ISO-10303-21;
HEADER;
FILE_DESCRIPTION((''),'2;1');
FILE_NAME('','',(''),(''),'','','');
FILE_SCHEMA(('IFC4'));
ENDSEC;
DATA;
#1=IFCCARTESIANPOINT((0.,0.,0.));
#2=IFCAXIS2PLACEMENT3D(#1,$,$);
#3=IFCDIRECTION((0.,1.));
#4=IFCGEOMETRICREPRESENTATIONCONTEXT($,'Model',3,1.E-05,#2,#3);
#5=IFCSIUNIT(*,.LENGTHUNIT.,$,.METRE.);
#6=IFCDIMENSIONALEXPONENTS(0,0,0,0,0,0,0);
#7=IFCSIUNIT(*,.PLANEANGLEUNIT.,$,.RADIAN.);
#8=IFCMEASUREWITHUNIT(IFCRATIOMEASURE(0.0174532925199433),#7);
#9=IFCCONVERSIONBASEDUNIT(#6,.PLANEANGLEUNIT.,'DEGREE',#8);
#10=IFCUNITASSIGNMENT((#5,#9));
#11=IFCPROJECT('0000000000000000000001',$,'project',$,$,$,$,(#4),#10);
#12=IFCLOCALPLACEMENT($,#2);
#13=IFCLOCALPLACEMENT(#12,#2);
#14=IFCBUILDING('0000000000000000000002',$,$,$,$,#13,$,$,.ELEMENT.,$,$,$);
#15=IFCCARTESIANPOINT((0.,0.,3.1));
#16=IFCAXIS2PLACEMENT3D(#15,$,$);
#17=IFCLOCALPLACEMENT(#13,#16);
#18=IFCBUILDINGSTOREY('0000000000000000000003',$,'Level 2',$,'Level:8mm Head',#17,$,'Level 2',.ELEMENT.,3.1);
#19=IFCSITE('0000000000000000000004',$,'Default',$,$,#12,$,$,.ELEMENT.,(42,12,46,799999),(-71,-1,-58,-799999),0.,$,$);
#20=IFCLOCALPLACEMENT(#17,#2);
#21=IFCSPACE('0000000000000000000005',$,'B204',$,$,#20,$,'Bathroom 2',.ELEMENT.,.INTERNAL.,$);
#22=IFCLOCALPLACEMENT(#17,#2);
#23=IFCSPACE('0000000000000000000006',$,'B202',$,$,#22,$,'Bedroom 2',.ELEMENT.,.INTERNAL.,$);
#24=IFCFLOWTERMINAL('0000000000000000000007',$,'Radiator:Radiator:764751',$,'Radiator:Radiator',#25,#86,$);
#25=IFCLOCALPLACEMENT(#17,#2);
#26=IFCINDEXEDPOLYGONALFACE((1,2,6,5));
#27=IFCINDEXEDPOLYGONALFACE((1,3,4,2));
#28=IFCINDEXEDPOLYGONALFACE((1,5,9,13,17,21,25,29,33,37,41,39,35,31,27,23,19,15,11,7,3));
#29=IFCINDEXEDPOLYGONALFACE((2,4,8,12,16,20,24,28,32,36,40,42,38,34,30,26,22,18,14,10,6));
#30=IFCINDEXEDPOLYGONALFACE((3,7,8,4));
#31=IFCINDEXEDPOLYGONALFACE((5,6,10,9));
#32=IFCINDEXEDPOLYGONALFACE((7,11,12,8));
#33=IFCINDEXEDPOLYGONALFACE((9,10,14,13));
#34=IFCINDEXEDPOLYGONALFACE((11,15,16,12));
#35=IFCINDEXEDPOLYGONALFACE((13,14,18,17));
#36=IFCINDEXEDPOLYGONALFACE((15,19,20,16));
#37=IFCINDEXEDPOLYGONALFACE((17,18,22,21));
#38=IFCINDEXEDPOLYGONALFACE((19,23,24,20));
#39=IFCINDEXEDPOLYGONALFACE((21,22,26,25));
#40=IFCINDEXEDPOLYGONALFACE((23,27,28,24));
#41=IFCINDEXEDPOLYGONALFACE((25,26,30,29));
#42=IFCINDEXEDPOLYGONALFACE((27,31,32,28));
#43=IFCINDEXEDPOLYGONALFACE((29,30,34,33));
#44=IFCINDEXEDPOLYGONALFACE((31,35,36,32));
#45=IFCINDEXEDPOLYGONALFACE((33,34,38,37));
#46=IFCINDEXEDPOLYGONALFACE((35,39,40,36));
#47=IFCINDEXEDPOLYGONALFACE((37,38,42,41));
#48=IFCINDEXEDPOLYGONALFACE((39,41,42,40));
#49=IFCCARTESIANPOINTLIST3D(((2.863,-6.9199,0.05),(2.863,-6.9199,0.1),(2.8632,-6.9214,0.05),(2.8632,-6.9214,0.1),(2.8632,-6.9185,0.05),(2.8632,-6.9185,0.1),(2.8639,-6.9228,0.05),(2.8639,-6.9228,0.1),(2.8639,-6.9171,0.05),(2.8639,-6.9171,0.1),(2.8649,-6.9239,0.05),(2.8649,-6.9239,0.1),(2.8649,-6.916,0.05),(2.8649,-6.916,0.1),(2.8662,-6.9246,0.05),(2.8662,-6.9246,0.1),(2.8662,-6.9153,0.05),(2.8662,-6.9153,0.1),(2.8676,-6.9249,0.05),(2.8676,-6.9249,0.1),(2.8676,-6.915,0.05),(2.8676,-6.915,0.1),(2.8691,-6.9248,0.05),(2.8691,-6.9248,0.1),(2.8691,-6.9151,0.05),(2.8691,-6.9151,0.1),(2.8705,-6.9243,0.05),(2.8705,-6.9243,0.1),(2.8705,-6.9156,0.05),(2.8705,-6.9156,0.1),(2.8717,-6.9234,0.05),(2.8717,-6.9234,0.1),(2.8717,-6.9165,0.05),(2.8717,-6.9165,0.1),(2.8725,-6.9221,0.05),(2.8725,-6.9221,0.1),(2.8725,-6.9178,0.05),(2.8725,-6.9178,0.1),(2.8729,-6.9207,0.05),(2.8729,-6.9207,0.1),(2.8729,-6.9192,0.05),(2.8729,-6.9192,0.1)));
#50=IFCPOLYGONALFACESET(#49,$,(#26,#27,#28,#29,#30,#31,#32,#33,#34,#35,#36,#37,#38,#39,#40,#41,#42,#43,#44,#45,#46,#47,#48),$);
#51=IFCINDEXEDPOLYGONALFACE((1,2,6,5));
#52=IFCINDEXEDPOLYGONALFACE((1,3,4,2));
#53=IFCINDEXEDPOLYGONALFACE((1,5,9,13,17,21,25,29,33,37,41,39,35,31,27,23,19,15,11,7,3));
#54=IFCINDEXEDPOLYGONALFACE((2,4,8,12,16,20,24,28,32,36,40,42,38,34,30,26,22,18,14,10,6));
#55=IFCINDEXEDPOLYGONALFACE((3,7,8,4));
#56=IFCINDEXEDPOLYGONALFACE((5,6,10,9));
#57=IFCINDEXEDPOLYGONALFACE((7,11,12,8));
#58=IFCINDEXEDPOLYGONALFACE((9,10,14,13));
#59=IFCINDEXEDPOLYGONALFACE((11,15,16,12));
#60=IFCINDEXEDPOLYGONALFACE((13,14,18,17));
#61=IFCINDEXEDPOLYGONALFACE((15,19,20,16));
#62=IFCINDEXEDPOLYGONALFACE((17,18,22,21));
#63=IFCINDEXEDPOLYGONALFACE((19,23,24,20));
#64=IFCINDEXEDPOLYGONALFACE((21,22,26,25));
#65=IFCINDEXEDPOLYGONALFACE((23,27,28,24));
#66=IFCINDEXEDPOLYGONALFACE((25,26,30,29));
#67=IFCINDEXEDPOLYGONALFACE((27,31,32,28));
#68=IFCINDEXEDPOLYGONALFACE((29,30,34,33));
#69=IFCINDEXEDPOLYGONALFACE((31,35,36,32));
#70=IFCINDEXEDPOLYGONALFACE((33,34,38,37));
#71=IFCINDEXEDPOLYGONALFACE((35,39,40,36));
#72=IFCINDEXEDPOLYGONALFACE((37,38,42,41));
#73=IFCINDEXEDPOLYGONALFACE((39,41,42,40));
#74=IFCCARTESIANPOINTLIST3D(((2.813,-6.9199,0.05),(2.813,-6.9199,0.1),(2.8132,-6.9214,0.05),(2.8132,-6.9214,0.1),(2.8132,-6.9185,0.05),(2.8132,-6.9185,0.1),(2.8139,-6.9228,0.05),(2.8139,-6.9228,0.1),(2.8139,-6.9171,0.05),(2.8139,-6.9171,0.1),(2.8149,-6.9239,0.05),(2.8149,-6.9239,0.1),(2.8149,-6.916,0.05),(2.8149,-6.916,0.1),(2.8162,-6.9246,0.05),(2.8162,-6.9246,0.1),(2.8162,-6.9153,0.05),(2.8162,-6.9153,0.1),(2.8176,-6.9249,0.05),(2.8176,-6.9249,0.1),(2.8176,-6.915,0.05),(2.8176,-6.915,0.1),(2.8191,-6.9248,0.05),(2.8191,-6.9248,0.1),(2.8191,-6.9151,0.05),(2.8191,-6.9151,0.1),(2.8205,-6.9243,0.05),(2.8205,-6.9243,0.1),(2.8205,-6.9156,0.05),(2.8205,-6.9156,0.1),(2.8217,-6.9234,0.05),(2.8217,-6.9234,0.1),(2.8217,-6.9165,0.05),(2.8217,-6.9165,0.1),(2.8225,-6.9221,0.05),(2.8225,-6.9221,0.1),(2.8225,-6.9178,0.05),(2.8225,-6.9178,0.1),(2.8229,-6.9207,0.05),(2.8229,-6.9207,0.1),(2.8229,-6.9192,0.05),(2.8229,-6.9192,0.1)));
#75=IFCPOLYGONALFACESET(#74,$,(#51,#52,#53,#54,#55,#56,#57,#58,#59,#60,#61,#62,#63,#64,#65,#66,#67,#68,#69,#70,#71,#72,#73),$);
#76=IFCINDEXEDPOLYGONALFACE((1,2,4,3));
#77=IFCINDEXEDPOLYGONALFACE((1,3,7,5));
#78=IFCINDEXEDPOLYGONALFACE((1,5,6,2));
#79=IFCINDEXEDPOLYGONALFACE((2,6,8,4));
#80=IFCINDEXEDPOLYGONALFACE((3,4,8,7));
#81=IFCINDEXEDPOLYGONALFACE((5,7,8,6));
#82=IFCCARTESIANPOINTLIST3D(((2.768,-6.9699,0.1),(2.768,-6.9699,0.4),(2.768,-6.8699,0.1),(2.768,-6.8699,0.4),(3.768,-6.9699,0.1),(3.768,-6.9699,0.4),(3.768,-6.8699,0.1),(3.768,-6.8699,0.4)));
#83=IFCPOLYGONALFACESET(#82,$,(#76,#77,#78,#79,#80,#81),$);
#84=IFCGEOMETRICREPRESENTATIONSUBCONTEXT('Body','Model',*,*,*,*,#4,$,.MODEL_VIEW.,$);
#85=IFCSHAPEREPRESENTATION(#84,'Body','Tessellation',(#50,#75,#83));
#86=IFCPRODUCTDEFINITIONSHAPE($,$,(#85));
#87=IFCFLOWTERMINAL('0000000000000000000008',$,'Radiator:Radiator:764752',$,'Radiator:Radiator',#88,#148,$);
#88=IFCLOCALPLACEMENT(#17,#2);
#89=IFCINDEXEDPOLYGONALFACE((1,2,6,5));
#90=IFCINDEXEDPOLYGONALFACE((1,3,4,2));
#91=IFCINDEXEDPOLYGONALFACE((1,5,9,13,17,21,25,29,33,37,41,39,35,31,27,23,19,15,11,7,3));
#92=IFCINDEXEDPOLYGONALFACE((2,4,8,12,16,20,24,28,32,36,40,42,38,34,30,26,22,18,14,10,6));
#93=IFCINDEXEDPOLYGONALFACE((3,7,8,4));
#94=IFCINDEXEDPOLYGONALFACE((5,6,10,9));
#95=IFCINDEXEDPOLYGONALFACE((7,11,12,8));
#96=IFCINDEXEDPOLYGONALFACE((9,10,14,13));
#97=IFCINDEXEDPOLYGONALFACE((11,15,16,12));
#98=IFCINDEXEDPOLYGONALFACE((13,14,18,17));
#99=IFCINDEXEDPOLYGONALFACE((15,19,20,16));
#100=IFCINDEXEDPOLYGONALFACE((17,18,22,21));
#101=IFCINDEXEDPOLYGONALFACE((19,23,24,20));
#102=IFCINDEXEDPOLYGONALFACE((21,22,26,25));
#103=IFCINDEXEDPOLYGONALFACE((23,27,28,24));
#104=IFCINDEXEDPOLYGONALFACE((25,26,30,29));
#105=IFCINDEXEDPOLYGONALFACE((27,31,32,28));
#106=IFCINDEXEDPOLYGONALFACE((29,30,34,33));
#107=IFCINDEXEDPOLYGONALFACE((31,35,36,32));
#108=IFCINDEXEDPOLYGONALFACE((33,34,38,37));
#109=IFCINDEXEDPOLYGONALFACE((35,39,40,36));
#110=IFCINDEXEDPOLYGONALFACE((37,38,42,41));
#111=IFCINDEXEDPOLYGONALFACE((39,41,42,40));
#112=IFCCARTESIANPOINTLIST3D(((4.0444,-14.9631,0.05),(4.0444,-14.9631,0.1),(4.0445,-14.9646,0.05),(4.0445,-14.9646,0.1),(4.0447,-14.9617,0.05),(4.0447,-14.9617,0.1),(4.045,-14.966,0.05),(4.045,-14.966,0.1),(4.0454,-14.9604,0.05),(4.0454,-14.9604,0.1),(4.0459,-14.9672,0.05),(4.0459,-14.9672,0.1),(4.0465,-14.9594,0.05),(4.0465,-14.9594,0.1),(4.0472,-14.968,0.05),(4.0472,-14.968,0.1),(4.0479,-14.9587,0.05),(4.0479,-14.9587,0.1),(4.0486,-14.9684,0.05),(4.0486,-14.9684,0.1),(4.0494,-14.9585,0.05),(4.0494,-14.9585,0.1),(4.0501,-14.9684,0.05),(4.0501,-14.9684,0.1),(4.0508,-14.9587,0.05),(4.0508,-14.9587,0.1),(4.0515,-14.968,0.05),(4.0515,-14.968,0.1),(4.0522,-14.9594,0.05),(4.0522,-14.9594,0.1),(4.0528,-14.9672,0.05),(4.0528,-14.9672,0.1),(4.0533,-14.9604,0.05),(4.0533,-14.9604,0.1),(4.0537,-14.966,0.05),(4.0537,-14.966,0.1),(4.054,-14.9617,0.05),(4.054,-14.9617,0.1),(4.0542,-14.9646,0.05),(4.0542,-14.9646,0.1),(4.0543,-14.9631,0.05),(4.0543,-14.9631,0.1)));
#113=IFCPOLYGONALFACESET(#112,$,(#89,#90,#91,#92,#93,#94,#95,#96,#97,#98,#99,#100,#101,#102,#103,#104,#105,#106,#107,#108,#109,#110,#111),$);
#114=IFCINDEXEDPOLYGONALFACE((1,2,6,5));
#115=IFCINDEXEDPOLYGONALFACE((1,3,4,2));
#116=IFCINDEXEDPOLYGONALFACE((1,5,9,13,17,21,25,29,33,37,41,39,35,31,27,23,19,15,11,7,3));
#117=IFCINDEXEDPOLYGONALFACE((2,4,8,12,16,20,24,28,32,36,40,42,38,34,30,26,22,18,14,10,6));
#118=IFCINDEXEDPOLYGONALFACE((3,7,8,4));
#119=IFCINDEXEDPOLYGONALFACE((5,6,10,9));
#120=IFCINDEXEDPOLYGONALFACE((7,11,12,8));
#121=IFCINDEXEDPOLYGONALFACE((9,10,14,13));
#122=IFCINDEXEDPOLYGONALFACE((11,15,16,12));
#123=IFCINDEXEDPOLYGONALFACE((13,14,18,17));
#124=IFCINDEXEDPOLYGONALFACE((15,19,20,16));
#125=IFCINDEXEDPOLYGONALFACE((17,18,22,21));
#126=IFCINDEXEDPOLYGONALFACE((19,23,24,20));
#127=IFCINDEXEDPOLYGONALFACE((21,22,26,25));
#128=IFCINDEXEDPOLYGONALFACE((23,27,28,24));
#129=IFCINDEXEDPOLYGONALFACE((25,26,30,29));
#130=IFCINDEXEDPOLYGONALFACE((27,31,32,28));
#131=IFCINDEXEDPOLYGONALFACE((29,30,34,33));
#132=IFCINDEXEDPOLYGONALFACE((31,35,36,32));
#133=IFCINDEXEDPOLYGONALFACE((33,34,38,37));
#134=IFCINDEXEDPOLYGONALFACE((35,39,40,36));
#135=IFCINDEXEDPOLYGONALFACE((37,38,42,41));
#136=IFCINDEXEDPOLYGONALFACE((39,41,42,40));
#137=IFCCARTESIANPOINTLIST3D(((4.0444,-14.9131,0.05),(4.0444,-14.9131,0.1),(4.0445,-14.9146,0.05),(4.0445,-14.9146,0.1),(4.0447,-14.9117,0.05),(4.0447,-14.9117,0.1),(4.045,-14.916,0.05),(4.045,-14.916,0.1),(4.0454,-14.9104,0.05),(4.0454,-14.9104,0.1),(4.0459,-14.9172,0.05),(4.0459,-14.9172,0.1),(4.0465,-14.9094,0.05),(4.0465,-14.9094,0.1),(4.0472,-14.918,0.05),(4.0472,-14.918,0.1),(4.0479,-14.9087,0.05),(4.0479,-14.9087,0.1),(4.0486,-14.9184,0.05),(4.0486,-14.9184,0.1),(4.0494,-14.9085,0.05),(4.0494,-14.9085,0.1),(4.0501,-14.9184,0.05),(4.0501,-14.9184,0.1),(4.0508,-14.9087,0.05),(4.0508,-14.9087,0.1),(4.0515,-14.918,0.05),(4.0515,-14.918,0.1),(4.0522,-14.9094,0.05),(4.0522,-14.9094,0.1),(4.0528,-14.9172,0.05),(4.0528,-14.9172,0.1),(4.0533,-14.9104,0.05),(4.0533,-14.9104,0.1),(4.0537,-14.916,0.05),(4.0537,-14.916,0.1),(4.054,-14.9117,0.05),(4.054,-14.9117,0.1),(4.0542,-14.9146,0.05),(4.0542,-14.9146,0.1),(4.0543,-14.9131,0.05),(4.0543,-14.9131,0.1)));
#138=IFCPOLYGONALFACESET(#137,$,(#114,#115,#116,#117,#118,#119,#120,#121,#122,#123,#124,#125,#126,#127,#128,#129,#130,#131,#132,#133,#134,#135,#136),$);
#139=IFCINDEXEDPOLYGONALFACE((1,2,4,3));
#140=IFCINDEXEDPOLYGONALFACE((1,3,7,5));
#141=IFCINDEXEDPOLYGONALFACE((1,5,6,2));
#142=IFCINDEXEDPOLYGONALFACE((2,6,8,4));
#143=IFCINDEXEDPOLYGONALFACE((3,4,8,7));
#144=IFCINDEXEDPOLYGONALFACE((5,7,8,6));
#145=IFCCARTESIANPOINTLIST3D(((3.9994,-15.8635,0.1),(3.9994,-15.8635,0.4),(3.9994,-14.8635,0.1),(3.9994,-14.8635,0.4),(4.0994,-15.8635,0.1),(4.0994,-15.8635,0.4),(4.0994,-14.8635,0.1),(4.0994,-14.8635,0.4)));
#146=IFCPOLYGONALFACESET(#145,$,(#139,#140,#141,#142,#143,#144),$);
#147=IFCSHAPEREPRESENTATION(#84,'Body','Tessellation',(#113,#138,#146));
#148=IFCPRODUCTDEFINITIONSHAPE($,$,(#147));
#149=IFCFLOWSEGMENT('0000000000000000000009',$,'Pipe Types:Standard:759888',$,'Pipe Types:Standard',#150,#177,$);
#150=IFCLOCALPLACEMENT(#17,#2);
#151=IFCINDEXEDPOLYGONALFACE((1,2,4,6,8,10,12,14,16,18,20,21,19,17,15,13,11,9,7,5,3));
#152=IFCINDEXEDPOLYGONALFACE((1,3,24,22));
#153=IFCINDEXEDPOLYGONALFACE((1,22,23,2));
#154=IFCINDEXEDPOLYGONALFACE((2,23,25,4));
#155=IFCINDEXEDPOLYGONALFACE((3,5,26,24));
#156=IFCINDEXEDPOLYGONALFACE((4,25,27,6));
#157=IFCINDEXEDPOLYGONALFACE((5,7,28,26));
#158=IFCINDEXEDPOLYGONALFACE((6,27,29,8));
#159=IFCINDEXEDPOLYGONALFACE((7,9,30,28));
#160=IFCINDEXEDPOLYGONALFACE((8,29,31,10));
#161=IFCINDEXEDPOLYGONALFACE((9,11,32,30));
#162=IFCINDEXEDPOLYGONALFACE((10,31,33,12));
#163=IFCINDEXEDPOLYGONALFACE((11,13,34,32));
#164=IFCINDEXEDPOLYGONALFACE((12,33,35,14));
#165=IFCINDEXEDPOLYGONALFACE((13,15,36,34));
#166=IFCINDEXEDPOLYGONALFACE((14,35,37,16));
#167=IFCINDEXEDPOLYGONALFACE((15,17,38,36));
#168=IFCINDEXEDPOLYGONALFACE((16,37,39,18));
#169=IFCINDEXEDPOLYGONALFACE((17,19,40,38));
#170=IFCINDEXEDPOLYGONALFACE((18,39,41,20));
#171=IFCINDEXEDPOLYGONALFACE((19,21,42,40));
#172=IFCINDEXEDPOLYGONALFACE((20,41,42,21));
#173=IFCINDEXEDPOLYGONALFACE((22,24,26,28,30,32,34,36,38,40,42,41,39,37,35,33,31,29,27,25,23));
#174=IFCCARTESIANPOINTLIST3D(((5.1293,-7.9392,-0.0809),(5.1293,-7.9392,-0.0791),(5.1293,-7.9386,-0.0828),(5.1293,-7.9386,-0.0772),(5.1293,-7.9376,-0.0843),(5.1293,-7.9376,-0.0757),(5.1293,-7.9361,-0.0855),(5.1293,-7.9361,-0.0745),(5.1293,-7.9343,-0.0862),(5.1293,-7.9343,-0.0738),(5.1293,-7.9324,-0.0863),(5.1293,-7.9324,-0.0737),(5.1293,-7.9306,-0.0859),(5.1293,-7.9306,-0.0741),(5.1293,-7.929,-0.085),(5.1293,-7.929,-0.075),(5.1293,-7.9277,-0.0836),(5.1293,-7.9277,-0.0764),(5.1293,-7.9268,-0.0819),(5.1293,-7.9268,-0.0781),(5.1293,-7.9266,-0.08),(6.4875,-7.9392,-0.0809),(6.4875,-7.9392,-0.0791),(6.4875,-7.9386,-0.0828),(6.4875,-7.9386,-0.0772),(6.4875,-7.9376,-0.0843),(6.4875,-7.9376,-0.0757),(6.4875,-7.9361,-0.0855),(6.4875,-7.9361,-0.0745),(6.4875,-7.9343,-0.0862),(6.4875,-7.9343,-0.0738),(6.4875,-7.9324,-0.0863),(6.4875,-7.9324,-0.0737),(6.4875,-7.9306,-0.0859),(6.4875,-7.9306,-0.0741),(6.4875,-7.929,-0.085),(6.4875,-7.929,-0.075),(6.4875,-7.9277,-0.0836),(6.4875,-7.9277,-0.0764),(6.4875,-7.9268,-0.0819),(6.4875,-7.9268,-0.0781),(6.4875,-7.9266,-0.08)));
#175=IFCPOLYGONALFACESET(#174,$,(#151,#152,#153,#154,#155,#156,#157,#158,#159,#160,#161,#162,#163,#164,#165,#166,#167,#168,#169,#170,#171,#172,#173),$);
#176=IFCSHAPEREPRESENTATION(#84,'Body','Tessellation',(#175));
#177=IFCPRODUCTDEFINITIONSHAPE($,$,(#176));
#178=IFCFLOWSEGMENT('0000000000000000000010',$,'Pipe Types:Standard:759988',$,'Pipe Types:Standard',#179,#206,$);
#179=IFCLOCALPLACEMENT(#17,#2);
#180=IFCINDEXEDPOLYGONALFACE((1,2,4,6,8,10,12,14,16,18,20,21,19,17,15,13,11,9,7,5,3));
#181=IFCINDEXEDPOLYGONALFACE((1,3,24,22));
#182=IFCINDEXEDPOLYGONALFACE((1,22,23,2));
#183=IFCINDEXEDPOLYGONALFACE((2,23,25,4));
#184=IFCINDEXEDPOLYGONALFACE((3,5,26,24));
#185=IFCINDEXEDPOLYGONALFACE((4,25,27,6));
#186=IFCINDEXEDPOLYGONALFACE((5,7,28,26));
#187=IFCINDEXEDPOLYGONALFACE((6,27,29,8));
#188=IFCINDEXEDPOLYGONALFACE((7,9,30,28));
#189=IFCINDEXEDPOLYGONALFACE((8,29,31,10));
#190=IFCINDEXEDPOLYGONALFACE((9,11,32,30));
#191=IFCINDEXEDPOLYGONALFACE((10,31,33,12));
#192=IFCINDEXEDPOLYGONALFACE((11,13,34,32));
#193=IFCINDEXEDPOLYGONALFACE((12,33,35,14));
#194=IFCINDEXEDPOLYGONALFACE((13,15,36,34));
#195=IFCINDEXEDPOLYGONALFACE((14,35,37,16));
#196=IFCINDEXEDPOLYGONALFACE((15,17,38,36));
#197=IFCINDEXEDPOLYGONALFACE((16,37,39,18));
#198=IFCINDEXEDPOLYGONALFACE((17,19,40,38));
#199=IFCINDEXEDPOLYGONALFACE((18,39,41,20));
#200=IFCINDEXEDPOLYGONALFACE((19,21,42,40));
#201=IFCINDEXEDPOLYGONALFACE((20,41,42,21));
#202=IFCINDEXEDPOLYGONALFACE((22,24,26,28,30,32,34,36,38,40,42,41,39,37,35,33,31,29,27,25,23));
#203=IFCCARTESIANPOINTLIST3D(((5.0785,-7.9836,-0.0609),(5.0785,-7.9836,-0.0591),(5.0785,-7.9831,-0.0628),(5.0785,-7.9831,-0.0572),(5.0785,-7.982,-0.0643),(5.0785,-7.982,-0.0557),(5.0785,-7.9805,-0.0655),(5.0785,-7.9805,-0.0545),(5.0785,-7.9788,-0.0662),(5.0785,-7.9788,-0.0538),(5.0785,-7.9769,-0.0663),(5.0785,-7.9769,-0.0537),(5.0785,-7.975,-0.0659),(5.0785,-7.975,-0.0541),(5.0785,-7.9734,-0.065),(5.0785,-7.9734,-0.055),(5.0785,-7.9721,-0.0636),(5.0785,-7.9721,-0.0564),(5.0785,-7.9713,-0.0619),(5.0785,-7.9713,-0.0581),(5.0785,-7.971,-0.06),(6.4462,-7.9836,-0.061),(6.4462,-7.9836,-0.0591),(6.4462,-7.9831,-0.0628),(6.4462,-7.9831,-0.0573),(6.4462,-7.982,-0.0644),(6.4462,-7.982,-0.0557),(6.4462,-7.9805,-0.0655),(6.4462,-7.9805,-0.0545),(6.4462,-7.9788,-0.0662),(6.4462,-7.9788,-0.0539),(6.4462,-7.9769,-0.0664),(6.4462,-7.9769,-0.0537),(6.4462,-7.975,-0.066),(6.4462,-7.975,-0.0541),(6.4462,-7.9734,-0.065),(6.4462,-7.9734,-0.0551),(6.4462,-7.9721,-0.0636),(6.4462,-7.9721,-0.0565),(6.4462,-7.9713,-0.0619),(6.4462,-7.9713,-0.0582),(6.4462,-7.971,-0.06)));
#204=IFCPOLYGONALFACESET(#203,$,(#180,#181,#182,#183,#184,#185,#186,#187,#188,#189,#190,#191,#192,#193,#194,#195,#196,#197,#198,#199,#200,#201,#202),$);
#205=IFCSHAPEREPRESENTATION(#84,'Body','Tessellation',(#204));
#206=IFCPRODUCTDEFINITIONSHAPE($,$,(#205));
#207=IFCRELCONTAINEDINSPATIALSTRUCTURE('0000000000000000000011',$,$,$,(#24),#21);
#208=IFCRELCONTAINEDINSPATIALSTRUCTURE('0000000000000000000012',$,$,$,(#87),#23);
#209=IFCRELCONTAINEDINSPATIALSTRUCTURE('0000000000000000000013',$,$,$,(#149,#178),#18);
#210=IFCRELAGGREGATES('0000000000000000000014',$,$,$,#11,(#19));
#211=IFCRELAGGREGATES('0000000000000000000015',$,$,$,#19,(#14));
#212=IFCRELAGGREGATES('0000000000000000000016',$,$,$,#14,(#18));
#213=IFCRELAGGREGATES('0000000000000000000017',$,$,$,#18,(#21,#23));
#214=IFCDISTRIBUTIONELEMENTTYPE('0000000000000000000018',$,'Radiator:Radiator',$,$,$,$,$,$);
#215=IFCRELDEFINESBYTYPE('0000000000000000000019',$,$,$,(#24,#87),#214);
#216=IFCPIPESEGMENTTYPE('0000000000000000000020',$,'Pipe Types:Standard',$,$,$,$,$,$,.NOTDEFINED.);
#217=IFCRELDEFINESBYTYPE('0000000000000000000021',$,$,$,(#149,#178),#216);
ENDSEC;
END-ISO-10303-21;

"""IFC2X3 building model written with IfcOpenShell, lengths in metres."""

from ifc_helpers import new_model, entity, si_unit, converted_unit, direction, frame, frame_2d, origin, origin_2d_with_axis, place, context, subcontext, project, spatial, rectangle, circle, extrude, source, transform, mapped, type_object, type_shapes, element, save


model = new_model("IFC2X3")

# Units and contexts
model_context = context("Model", 3, precision=1e-05, world=origin(), true_north=direction((0.0, 1.0)))
body_context = subcontext(model_context, "Body", "Model", "MODEL_VIEW")
ifc_project = project(units=[si_unit("LENGTHUNIT", "METRE"), converted_unit("PLANEANGLEUNIT", "DEGREE", entity("IfcRatioMeasure", 0.0174532925199433), si_unit("PLANEANGLEUNIT", "RADIAN"), dimensions=[0, 0, 0, 0, 0, 0, 0])], contexts=[model_context])

# Site, building, storey
site_placement = place(None, origin())
site = spatial("IfcSite", under=ifc_project, at=site_placement, Name="Default", CompositionType="ELEMENT", RefLatitude=(42, 12, 46, 799999), RefLongitude=(-71, -1, -58, -799999), RefElevation=0.0)
building_placement = place(site_placement, origin())
building = spatial("IfcBuilding", under=site, at=building_placement, CompositionType="ELEMENT")
storey_placement = place(building_placement, frame((0.0, 0.0, 3.1)))
storey = spatial("IfcBuildingStorey", under=building, at=storey_placement, Name="Level 2", ObjectType="Level:8mm Head", LongName="Level 2", CompositionType="ELEMENT", Elevation=3.1)

# Shared definitions
distribution_element_type = type_object("IfcDistributionElementType", Name="Radiator:Radiator")
shared_shape = source(origin(), body_context, "Body", "SweptSolid", [
    extrude(circle(Radius=0.005, at=frame_2d((0.0, 0.0), x_axis=(1.0, 0.0))), frame((0.4, 0.0, -0.05)), (0.0, 0.0, 1.0), 0.05),
    extrude(circle(Radius=0.005, at=frame_2d((0.0, 0.0), x_axis=(1.0, 0.0))), frame((0.45, 0.0, -0.05)), (0.0, 0.0, 1.0), 0.05),
    extrude(rectangle(XDim=1.0, YDim=0.1, at=origin_2d_with_axis()), frame((0.0, 0.0, 0.0), z_axis=(0.0, 0.0, 1.0), x_axis=(-1.0, 0.0, 0.0)), (0.0, 0.0, 1.0), 0.3),
])
type_shapes(distribution_element_type, [shared_shape])

# Shared definitions
space_1_placement = place(storey_placement, origin())
space_1 = spatial("IfcSpace", under=storey, at=space_1_placement, Name="B204", LongName="Bathroom 2", CompositionType="ELEMENT", InteriorOrExteriorSpace="INTERNAL")

# Flow terminal
flow_terminal_1_placement = place(space_1_placement, frame((3.268, -6.9199, 0.1), z_axis=(0.0, 0.0, 1.0), x_axis=(-1.0, 0.0, 0.0)))
element("IfcFlowTerminal", 1, at=flow_terminal_1_placement, inside=space_1, type_object=distribution_element_type, Name="Radiator:Radiator:764751", ObjectType="Radiator:Radiator", context=body_context, shape_type="MappedRepresentation", body=[
    mapped(shared_shape, transform((0.0, 0.0, 0.0), scale=1.0)),
])

# Shared definitions
space_2_placement = place(storey_placement, origin())
space_2 = spatial("IfcSpace", under=storey, at=space_2_placement, Name="B202", LongName="Bedroom 2", CompositionType="ELEMENT", InteriorOrExteriorSpace="INTERNAL")

# Flow terminal
flow_terminal_2_placement = place(space_2_placement, frame((4.0494, -15.3635, 0.1), z_axis=(0.0, 0.0, 1.0), x_axis=(0.0, 1.0, 0.0)))
element("IfcFlowTerminal", 2, at=flow_terminal_2_placement, inside=space_2, type_object=distribution_element_type, Name="Radiator:Radiator:764752", ObjectType="Radiator:Radiator", context=body_context, shape_type="MappedRepresentation", body=[
    mapped(shared_shape, transform((0.0, 0.0, 0.0), scale=1.0)),
])

# Flow segments
pipe_segment_type = type_object("IfcPipeSegmentType", Name="Pipe Types:Standard", PredefinedType="NOTDEFINED")
flow_segment_1_placement = place(storey_placement, origin())
element("IfcFlowSegment", 3, at=flow_segment_1_placement, inside=storey, type_object=pipe_segment_type, Name="Pipe Types:Standard:759888", ObjectType="Pipe Types:Standard", context=body_context, shape_type="SweptSolid", body=[
    extrude(circle(Radius=0.0063, at=frame_2d((0.0, 0.0), x_axis=(1.0, 0.0))), frame((5.1293, -7.9329, -0.08), z_axis=(1.0, 0.0, 0.0), x_axis=(0.0, 1.0, 0.0)), (0.0, 0.0, 1.0), 1.3582),
])
flow_segment_2_placement = place(storey_placement, origin())
element("IfcFlowSegment", 4, at=flow_segment_2_placement, inside=storey, type_object=pipe_segment_type, Name="Pipe Types:Standard:759988", ObjectType="Pipe Types:Standard", context=body_context, shape_type="SweptSolid", body=[
    extrude(circle(Radius=0.0063, at=origin_2d_with_axis()), frame((5.0785, -7.9774, -0.06), z_axis=(1.0, 0.0, -0.000032), x_axis=(0.0, 1.0, 0.0)), (0.0, 0.0, 1.0), 1.3677),
])

save(model, "model.ifc")
